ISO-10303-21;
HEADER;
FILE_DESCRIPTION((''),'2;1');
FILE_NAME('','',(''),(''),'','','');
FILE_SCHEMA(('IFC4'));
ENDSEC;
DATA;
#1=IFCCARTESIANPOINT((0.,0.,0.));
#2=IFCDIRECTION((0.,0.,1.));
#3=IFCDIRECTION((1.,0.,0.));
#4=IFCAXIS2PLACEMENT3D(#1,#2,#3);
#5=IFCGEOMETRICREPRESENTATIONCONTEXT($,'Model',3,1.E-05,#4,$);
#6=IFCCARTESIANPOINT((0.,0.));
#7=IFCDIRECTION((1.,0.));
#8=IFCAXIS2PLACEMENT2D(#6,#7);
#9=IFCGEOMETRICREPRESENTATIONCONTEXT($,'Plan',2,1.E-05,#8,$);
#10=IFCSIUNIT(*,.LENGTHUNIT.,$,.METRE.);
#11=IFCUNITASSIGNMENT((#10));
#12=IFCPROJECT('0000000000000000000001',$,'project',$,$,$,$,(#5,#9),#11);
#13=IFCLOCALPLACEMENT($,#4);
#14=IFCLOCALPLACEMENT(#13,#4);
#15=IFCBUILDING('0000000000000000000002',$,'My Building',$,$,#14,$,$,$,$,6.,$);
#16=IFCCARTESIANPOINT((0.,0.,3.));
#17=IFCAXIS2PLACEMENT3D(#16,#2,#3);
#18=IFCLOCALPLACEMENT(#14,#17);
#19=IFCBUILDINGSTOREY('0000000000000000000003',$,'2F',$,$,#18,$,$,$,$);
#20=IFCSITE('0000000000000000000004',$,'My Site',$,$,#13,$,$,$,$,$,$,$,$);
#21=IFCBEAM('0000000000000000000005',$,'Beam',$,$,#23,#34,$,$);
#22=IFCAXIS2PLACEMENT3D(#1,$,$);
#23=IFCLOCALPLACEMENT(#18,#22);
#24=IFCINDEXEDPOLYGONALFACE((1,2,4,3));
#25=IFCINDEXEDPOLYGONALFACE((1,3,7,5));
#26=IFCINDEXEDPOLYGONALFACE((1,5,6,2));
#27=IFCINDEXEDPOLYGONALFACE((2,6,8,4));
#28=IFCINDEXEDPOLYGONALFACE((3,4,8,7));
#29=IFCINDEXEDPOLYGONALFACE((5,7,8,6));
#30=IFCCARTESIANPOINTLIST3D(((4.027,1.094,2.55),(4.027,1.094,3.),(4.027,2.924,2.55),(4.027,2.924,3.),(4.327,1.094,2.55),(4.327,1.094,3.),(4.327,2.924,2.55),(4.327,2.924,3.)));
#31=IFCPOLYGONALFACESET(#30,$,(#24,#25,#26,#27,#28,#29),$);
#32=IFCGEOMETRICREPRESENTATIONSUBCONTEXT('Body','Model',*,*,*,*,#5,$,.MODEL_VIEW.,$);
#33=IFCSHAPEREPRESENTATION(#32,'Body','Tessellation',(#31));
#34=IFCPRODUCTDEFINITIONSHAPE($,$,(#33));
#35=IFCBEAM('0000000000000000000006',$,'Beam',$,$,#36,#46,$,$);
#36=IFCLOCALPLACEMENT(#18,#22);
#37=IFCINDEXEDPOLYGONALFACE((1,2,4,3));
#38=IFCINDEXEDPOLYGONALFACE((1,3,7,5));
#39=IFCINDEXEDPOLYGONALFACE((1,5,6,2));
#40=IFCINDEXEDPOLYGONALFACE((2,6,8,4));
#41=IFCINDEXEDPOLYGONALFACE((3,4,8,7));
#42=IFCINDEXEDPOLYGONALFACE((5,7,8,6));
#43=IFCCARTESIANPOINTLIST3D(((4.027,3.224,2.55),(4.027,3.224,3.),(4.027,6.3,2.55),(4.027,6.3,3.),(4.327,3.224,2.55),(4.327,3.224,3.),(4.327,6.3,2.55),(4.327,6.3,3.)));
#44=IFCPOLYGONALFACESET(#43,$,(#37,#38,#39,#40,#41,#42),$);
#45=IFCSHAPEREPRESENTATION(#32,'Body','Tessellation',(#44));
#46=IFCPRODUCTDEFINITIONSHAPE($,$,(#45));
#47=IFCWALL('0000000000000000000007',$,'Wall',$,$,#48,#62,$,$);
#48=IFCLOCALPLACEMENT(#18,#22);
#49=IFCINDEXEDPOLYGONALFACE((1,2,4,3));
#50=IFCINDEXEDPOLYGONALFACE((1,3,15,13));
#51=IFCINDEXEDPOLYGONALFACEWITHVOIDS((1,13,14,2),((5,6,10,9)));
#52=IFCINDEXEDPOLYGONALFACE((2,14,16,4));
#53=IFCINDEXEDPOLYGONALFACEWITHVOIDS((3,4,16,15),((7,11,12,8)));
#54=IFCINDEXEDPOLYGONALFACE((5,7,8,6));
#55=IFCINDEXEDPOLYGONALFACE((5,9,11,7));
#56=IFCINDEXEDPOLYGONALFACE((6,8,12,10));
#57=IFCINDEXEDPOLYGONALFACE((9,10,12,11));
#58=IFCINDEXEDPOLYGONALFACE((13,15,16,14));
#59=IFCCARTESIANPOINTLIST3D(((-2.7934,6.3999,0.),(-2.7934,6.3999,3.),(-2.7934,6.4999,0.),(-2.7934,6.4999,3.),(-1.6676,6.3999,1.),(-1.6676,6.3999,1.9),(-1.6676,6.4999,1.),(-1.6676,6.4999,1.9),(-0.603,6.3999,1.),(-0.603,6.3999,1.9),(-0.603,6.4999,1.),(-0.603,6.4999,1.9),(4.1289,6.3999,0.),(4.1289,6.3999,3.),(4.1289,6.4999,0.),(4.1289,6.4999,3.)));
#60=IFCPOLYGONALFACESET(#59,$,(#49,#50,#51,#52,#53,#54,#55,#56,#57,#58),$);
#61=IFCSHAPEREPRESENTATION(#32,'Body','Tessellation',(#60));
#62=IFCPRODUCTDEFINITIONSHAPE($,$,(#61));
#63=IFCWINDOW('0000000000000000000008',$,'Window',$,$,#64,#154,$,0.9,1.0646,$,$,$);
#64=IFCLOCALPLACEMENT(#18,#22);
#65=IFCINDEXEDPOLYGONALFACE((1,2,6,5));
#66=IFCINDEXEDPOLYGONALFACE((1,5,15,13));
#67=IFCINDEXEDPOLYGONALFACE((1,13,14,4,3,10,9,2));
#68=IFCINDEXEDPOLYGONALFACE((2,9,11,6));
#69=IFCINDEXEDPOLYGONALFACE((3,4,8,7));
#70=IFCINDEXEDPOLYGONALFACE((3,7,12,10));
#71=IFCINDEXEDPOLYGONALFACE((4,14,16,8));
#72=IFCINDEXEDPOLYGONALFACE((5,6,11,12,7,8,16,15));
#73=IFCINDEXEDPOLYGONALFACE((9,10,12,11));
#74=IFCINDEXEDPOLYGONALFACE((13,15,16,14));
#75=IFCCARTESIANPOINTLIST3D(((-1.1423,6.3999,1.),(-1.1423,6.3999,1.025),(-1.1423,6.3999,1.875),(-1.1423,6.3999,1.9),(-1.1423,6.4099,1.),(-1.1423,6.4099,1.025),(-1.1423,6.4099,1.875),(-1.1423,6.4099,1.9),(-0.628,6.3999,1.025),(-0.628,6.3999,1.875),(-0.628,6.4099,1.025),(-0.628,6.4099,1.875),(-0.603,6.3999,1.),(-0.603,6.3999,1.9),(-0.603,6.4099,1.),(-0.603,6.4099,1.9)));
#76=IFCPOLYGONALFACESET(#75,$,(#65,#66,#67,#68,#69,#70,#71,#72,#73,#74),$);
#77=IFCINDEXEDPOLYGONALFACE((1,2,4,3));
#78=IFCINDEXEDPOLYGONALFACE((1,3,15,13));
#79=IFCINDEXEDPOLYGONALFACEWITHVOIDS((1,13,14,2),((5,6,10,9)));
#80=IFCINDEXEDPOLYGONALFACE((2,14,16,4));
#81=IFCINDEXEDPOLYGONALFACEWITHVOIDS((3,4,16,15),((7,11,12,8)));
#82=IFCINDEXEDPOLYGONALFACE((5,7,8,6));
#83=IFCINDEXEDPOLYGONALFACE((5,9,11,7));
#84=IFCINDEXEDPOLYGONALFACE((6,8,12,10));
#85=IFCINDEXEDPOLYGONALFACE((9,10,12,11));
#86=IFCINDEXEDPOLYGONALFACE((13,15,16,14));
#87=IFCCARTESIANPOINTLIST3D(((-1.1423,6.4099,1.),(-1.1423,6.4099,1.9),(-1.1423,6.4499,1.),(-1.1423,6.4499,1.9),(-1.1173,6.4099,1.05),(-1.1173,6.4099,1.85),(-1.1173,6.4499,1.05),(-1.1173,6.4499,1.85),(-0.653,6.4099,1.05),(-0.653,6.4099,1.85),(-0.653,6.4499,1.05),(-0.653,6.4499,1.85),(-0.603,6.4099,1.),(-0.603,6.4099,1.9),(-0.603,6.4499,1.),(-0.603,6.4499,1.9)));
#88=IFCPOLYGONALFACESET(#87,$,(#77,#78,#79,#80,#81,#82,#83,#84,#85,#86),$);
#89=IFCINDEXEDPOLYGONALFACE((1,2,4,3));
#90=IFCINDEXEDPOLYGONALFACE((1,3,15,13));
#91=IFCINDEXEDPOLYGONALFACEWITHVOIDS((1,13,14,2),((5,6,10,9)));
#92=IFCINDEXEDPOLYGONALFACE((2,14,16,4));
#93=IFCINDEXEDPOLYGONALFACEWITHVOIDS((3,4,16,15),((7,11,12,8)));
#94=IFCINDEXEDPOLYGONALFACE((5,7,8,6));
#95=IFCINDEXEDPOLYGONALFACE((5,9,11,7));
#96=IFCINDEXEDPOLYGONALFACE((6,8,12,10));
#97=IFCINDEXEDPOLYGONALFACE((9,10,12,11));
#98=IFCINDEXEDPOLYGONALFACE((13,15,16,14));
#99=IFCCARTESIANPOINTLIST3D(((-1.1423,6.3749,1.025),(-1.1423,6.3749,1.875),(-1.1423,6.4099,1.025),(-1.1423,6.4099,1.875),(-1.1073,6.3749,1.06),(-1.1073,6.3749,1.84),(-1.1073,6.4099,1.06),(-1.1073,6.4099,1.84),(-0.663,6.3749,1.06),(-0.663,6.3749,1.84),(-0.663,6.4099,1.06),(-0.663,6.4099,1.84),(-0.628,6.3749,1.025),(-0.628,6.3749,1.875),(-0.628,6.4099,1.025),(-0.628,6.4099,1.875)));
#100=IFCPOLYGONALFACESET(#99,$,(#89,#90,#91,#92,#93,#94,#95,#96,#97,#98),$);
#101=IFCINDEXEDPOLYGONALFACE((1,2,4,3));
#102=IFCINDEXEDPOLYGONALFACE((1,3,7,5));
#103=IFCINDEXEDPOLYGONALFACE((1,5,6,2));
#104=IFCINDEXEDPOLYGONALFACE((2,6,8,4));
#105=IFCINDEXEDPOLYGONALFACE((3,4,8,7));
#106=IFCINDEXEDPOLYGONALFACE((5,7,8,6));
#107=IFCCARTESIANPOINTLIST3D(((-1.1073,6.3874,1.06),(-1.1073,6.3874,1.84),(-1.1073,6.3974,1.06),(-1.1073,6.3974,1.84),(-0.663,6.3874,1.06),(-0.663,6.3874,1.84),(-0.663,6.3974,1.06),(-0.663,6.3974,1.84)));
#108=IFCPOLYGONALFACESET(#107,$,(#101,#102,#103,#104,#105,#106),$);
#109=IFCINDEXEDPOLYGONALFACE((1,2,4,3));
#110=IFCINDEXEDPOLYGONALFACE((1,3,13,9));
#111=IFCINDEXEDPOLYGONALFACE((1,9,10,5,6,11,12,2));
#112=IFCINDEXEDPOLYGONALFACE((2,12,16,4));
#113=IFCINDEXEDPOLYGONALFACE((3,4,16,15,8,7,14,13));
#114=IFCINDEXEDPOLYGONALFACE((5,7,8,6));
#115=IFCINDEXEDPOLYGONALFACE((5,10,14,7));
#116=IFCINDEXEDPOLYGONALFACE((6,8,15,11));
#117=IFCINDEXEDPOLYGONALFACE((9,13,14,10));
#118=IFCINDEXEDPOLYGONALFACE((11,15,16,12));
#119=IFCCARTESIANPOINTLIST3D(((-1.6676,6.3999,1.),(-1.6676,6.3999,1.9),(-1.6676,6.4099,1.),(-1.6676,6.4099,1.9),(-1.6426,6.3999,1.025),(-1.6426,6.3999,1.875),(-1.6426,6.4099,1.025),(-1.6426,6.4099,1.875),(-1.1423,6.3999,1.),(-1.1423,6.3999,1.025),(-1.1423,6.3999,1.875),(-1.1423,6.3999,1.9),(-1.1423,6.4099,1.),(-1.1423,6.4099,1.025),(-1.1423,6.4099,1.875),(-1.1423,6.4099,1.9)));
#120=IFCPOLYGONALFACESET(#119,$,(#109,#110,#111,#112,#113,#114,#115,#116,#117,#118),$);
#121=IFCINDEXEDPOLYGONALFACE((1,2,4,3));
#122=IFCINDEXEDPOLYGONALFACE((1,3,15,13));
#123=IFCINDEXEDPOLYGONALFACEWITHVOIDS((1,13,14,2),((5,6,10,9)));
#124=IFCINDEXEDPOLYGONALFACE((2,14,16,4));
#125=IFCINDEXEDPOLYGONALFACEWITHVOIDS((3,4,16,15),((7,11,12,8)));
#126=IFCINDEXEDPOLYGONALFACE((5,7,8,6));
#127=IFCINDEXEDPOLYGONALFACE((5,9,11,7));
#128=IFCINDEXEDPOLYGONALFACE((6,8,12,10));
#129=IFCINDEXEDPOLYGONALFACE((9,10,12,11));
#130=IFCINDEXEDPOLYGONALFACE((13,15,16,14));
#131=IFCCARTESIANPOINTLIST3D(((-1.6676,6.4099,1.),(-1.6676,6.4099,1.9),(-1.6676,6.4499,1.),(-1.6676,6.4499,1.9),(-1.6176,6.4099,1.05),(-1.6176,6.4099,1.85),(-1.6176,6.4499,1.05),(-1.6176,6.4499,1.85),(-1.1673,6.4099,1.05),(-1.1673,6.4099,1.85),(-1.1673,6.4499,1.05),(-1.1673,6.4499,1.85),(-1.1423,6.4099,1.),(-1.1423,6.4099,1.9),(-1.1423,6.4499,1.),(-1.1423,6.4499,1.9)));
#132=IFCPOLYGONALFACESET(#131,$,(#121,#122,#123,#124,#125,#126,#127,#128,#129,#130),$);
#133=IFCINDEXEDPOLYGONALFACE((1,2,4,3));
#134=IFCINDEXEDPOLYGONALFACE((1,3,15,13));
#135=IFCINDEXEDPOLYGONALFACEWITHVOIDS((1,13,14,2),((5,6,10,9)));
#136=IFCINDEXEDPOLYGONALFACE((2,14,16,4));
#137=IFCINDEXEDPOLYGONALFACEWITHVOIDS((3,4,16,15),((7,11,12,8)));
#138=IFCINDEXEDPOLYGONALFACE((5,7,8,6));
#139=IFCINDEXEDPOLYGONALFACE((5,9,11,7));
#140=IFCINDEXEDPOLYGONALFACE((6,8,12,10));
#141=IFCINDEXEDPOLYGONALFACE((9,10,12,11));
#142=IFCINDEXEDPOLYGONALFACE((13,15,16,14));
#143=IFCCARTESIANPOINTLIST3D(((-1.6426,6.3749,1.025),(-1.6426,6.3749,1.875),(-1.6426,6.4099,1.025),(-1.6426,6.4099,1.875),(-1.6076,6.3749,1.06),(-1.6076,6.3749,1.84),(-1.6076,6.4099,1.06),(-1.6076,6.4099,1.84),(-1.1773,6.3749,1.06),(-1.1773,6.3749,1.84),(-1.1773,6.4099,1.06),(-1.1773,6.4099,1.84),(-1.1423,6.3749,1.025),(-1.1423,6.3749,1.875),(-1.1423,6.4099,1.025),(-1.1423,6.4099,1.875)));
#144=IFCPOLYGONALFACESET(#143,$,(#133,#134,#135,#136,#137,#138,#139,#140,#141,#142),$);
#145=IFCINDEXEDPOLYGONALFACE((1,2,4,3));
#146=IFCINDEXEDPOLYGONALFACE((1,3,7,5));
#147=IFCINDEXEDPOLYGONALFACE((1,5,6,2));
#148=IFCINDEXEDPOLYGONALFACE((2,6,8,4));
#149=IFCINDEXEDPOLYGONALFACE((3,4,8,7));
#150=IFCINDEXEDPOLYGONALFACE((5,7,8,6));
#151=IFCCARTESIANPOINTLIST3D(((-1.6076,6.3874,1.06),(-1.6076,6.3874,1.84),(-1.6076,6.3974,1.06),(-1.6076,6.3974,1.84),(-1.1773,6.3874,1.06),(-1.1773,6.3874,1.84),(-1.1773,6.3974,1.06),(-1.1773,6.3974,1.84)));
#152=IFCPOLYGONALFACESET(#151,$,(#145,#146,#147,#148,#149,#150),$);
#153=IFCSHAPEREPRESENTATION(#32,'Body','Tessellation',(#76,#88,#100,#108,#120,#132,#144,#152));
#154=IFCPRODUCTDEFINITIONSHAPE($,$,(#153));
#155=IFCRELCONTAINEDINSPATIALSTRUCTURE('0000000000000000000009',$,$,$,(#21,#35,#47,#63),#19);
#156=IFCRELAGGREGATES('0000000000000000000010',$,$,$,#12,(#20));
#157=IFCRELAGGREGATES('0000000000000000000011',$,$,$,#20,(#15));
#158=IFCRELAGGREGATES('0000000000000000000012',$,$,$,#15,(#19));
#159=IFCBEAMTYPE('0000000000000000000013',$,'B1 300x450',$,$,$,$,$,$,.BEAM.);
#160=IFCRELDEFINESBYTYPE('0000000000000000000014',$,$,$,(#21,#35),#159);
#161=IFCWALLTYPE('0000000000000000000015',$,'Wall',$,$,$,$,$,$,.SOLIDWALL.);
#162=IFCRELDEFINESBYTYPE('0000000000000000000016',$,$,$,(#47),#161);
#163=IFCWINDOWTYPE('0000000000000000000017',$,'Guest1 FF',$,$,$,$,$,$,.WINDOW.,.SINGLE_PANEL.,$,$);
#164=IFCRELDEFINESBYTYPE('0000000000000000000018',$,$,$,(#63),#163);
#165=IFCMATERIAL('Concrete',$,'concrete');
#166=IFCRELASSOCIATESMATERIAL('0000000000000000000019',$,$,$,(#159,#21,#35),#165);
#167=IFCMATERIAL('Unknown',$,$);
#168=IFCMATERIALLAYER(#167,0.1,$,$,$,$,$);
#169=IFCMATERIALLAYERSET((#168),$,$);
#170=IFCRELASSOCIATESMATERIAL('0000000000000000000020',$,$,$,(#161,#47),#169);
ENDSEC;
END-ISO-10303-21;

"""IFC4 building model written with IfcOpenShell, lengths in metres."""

from ifc_helpers import new_model, entity, si_unit, frame, origin_with_axes, origin_2d_with_axis, place, context, subcontext, project, spatial, line, indexed_curve, rectangle, outline, extrude, shape, source, transform, mapped, material, layer, layer_set, layer_usage, material_profile, profile_set, profile_usage, type_object, type_shapes, element, fill, save


model = new_model("IFC4")

# Units and contexts
model_context = context("Model", 3, precision=1e-05, world=origin_with_axes())
plan_context = context("Plan", 2, precision=1e-05, world=origin_2d_with_axis())
body_context_1 = subcontext(model_context, "Body", "Model", "MODEL_VIEW")
body_context_2 = subcontext(plan_context, "Body", "Plan", "PLAN_VIEW")
ifc_project = project(units=[si_unit("LENGTHUNIT", "METRE")], contexts=[model_context, plan_context])

# Site, building, storey
site_placement = place(None, origin_with_axes())
site = spatial("IfcSite", under=ifc_project, at=site_placement, Name="My Site")
building_placement = place(site_placement, origin_with_axes())
building = spatial("IfcBuilding", under=site, at=building_placement, Name="My Building", ElevationOfTerrain=6.0)
storey_placement = place(building_placement, frame((0.0, 0.0, 3.0), z_axis=(0.0, 0.0, 1.0), x_axis=(1.0, 0.0, 0.0)))
storey = spatial("IfcBuildingStorey", under=building, at=storey_placement, Name="2F")

# Shared definitions
ifc_material_1 = material(Name="Concrete", Category="concrete")

# Beams
ifc_material_profile_1 = material_profile(ifc_material_1, rectangle(XDim=0.3, YDim=0.45))
ifc_profile_set_1 = profile_set([ifc_material_profile_1], Name="B1 300x450")
beam_type = type_object("IfcBeamType", Name="B1 300x450", PredefinedType="BEAM", material=ifc_profile_set_1)
ifc_profile_usage_1 = profile_usage(ifc_profile_set_1, cardinal=8)
beam_1_placement = place(storey_placement, frame((4.177, 1.094, 2.975), z_axis=(0.0, 1.0, 0.0), x_axis=(-1.0, 0.0, 0.0)))
element("IfcBeam", 1, at=beam_1_placement, inside=storey, type_object=beam_type, material=ifc_profile_usage_1, Name="Beam", context=body_context_1, shape_type="SweptSolid", body=[
    extrude(rectangle(XDim=0.3, YDim=0.45), frame((0.0, -0.2, 0.0), z_axis=(0.0, 0.0, 1.0), x_axis=(1.0, 0.0, 0.0)), (0.0, 0.0, 1.0), 1.83),
])
ifc_profile_usage_2 = profile_usage(ifc_profile_set_1, cardinal=8)
beam_2_placement = place(storey_placement, frame((4.177, 3.224, 2.975), z_axis=(0.0, 1.0, 0.0), x_axis=(-1.0, 0.0, 0.0)))
element("IfcBeam", 2, at=beam_2_placement, inside=storey, type_object=beam_type, material=ifc_profile_usage_2, Name="Beam", context=body_context_1, shape_type="SweptSolid", body=[
    extrude(rectangle(XDim=0.3, YDim=0.45), frame((0.0, -0.2, 0.0), z_axis=(0.0, 0.0, 1.0), x_axis=(1.0, 0.0, 0.0)), (0.0, 0.0, 1.0), 3.076),
])

# Wall, opening, window
ifc_material_2 = material(Name="Unknown")
ifc_layer = layer(ifc_material_2, 0.1)
ifc_layer_set = layer_set([ifc_layer])
ifc_layer_usage_1 = layer_usage(ifc_layer_set, "AXIS2", "POSITIVE", 0.0)
wall_type = type_object("IfcWallType", Name="Wall", PredefinedType="SOLIDWALL", material=ifc_layer_set)
wall_1_placement = place(storey_placement, frame((4.1289, 6.4999, 0.0), z_axis=(0.0, 0.0, 1.0), x_axis=(-1.0, 0.0, 0.0)))
wall_1 = element("IfcWall", 3, at=wall_1_placement, inside=storey, type_object=wall_type, material=ifc_layer_usage_1, Name="Wall", context=body_context_1, shape_type="SweptSolid", body=[
    extrude(outline(indexed_curve([(0.0, 0.0), (0.0, 0.1), (6.9223, 0.1), (6.9223, 0.0)], segments=[line(1, 2, 3, 4, 1)])), origin_with_axes(), (0.0, 0.0, 1.0), 3.0),
])
shared_shape_1 = source(origin_with_axes(), body_context_1, "Body", "SweptSolid", [
    extrude(outline(indexed_curve([(0.0, 0.0), (1.0646, 0.0), (1.0646, 0.9), (0.0, 0.9)], segments=[line(1, 2, 3, 4, 1)])), frame((0.0, -0.6, 0.0), z_axis=(0.0, -1.0, 0.0), x_axis=(1.0, 0.0, 0.0)), (0.0, 0.0, -1.0), 1.2),
])
opening_1_placement = place(wall_1_placement, frame((4.7319, 0.0, 1.0), z_axis=(0.0, 0.0, 1.0), x_axis=(1.0, 0.0, 0.0)))
opening_1 = element("IfcOpeningElement", 4, at=opening_1_placement, cuts=wall_1, PredefinedType="OPENING", context=body_context_1, shape_type="MappedRepresentation", body=[
    mapped(shared_shape_1, transform((0.0, 0.0, 0.0), x_axis=(1.0, 0.0, 0.0), y_axis=(0.0, 1.0, 0.0), z_axis=(0.0, 0.0, 1.0), scale=1.0)),
])
window_type_1 = type_object("IfcWindowType", Name="Guest1 FF", PartitioningType="SINGLE_PANEL", PredefinedType="WINDOW")
shared_shape_2 = source(origin_with_axes(), body_context_1, "Body", "SweptSolid", [
    extrude(outline(indexed_curve([(0.5393, 0.0), (0.0, 0.0), (0.0, 0.9), (0.5393, 0.9), (0.5393, 0.875), (0.025, 0.875), (0.025, 0.025), (0.5393, 0.025)], segments=[line(1, 2, 3, 4, 5, 6, 7, 8, 1)])), frame((0.0, 0.09, 0.0), z_axis=(0.0, -1.0, 0.0), x_axis=(1.0, 0.0, 0.0)), (0.0, 0.0, -1.0), 0.01),
    extrude(outline(indexed_curve([(0.0, 0.0), (0.5393, 0.0), (0.5393, 0.9), (0.0, 0.9)], segments=[line(1, 2, 3, 4, 1)]), holes=[indexed_curve([(0.05, 0.05), (0.5143, 0.05), (0.5143, 0.85), (0.05, 0.85)], segments=[line(1, 2, 3, 4, 1)])]), frame((0.0, 0.05, 0.0), z_axis=(0.0, -1.0, 0.0), x_axis=(1.0, 0.0, 0.0)), (0.0, 0.0, -1.0), 0.04),
    extrude(outline(indexed_curve([(0.0, 0.0), (0.5143, 0.0), (0.5143, 0.85), (0.0, 0.85)], segments=[line(1, 2, 3, 4, 1)]), holes=[indexed_curve([(0.035, 0.035), (0.4793, 0.035), (0.4793, 0.815), (0.035, 0.815)], segments=[line(1, 2, 3, 4, 1)])]), frame((0.025, 0.09, 0.025), z_axis=(0.0, -1.0, 0.0), x_axis=(1.0, 0.0, 0.0)), (0.0, 0.0, -1.0), 0.035),
    extrude(outline(indexed_curve([(0.035, 0.035), (0.4793, 0.035), (0.4793, 0.815), (0.035, 0.815)], segments=[line(1, 2, 3, 4, 1)])), frame((0.025, 0.1025, 0.025), z_axis=(0.0, -1.0, 0.0), x_axis=(1.0, 0.0, 0.0)), (0.0, 0.0, -1.0), 0.01),
    extrude(outline(indexed_curve([(0.0, 0.9), (0.5253, 0.9), (0.5253, 0.0), (0.0, 0.0), (0.0, 0.025), (0.5003, 0.025), (0.5003, 0.875), (0.0, 0.875)], segments=[line(1, 2, 3, 4, 5, 6, 7, 8, 1)])), frame((0.5393, 0.09, 0.0), z_axis=(0.0, -1.0, 0.0), x_axis=(1.0, 0.0, 0.0)), (0.0, 0.0, -1.0), 0.01),
    extrude(outline(indexed_curve([(0.0, 0.0), (0.5253, 0.0), (0.5253, 0.9), (0.0, 0.9)], segments=[line(1, 2, 3, 4, 1)]), holes=[indexed_curve([(0.025, 0.05), (0.4753, 0.05), (0.4753, 0.85), (0.025, 0.85)], segments=[line(1, 2, 3, 4, 1)])]), frame((0.5393, 0.05, 0.0), z_axis=(0.0, -1.0, 0.0), x_axis=(1.0, 0.0, 0.0)), (0.0, 0.0, -1.0), 0.04),
    extrude(outline(indexed_curve([(0.0, 0.0), (0.5003, 0.0), (0.5003, 0.85), (0.0, 0.85)], segments=[line(1, 2, 3, 4, 1)]), holes=[indexed_curve([(0.035, 0.035), (0.4653, 0.035), (0.4653, 0.815), (0.035, 0.815)], segments=[line(1, 2, 3, 4, 1)])]), frame((0.5393, 0.09, 0.025), z_axis=(0.0, -1.0, 0.0), x_axis=(1.0, 0.0, 0.0)), (0.0, 0.0, -1.0), 0.035),
    extrude(outline(indexed_curve([(0.035, 0.035), (0.4653, 0.035), (0.4653, 0.815), (0.035, 0.815)], segments=[line(1, 2, 3, 4, 1)])), frame((0.5393, 0.1025, 0.025), z_axis=(0.0, -1.0, 0.0), x_axis=(1.0, 0.0, 0.0)), (0.0, 0.0, -1.0), 0.01),
])
shared_shape_3 = source(origin_with_axes(), body_context_2, "Body", "Curve2D", [
    entity("IfcIndexedPolyCurve", entity("IfcCartesianPointList2D", [[0.05, 0.05], [0.5143, 0.05]])),
    entity("IfcIndexedPolyCurve", entity("IfcCartesianPointList2D", [[0.0, 0.1], [0.025, 0.1], [0.025, 0.09], [0.05, 0.09], [0.05, 0.05], [0.0, 0.05]]), [entity("IfcLineIndex", [1, 2, 3, 4, 5, 6, 1])]),
    entity("IfcIndexedPolyCurve", entity("IfcCartesianPointList2D", [[0.5393, 0.1], [0.5393, 0.1], [0.5393, 0.09], [0.5143, 0.09], [0.5143, 0.05], [0.5393, 0.05]])),
    entity("IfcIndexedPolyCurve", entity("IfcCartesianPointList2D", [[0.025, 0.09], [0.06, 0.09], [0.06, 0.125], [0.025, 0.125]]), [entity("IfcLineIndex", [1, 2, 3, 4, 1])]),
    entity("IfcIndexedPolyCurve", entity("IfcCartesianPointList2D", [[0.5393, 0.09], [0.5043, 0.09], [0.5043, 0.125], [0.5393, 0.125]]), [entity("IfcLineIndex", [1, 2, 3, 4, 1])]),
    entity("IfcIndexedPolyCurve", entity("IfcCartesianPointList2D", [[0.06, 0.09], [0.5043, 0.09]])),
    entity("IfcIndexedPolyCurve", entity("IfcCartesianPointList2D", [[0.06, 0.125], [0.5043, 0.125]])),
    entity("IfcIndexedPolyCurve", entity("IfcCartesianPointList2D", [[0.06, 0.1075], [0.5043, 0.1075]])),
    entity("IfcIndexedPolyCurve", entity("IfcCartesianPointList2D", [[0.5643, 0.05], [1.0146, 0.05]])),
    entity("IfcIndexedPolyCurve", entity("IfcCartesianPointList2D", [[0.5393, 0.1], [0.5393, 0.1], [0.5393, 0.09], [0.5643, 0.09], [0.5643, 0.05], [0.5393, 0.05]])),
    entity("IfcIndexedPolyCurve", entity("IfcCartesianPointList2D", [[1.0646, 0.1], [1.0396, 0.1], [1.0396, 0.09], [1.0146, 0.09], [1.0146, 0.05], [1.0646, 0.05]]), [entity("IfcLineIndex", [1, 2, 3, 4, 5, 6, 1])]),
    entity("IfcIndexedPolyCurve", entity("IfcCartesianPointList2D", [[0.5393, 0.09], [0.5743, 0.09], [0.5743, 0.125], [0.5393, 0.125]]), [entity("IfcLineIndex", [1, 2, 3, 4, 1])]),
    entity("IfcIndexedPolyCurve", entity("IfcCartesianPointList2D", [[1.0396, 0.09], [1.0046, 0.09], [1.0046, 0.125], [1.0396, 0.125]]), [entity("IfcLineIndex", [1, 2, 3, 4, 1])]),
    entity("IfcIndexedPolyCurve", entity("IfcCartesianPointList2D", [[0.5743, 0.09], [1.0046, 0.09]])),
    entity("IfcIndexedPolyCurve", entity("IfcCartesianPointList2D", [[0.5743, 0.125], [1.0046, 0.125]])),
    entity("IfcIndexedPolyCurve", entity("IfcCartesianPointList2D", [[0.5743, 0.1075], [1.0046, 0.1075]])),
])
type_shapes(window_type_1, [shared_shape_2, shared_shape_3])
window_1_placement = place(opening_1_placement, frame((0.0, 0.0, 0.0), z_axis=(0.0, 0.0, 1.0), x_axis=(1.0, 0.0, 0.0)))
window_1 = element("IfcWindow", 5, at=window_1_placement, inside=storey, type_object=window_type_1, Name="Window", OverallHeight=0.9, OverallWidth=1.0646, shapes=[
    shape(body_context_1, "Body", "MappedRepresentation", [mapped(shared_shape_2, transform((0.0, 0.0, 0.0), x_axis=(1.0, 0.0, 0.0), y_axis=(0.0, 1.0, 0.0), z_axis=(0.0, 0.0, 1.0), scale=1.0))]),
    shape(body_context_2, "Body", "MappedRepresentation", [mapped(shared_shape_3, transform((0.0, 0.0, 0.0), x_axis=(1.0, 0.0, 0.0), y_axis=(0.0, 1.0, 0.0), z_axis=(0.0, 0.0, 1.0), scale=1.0))]),
])
fill(opening_1, window_1)

save(model, "model.ifc")
